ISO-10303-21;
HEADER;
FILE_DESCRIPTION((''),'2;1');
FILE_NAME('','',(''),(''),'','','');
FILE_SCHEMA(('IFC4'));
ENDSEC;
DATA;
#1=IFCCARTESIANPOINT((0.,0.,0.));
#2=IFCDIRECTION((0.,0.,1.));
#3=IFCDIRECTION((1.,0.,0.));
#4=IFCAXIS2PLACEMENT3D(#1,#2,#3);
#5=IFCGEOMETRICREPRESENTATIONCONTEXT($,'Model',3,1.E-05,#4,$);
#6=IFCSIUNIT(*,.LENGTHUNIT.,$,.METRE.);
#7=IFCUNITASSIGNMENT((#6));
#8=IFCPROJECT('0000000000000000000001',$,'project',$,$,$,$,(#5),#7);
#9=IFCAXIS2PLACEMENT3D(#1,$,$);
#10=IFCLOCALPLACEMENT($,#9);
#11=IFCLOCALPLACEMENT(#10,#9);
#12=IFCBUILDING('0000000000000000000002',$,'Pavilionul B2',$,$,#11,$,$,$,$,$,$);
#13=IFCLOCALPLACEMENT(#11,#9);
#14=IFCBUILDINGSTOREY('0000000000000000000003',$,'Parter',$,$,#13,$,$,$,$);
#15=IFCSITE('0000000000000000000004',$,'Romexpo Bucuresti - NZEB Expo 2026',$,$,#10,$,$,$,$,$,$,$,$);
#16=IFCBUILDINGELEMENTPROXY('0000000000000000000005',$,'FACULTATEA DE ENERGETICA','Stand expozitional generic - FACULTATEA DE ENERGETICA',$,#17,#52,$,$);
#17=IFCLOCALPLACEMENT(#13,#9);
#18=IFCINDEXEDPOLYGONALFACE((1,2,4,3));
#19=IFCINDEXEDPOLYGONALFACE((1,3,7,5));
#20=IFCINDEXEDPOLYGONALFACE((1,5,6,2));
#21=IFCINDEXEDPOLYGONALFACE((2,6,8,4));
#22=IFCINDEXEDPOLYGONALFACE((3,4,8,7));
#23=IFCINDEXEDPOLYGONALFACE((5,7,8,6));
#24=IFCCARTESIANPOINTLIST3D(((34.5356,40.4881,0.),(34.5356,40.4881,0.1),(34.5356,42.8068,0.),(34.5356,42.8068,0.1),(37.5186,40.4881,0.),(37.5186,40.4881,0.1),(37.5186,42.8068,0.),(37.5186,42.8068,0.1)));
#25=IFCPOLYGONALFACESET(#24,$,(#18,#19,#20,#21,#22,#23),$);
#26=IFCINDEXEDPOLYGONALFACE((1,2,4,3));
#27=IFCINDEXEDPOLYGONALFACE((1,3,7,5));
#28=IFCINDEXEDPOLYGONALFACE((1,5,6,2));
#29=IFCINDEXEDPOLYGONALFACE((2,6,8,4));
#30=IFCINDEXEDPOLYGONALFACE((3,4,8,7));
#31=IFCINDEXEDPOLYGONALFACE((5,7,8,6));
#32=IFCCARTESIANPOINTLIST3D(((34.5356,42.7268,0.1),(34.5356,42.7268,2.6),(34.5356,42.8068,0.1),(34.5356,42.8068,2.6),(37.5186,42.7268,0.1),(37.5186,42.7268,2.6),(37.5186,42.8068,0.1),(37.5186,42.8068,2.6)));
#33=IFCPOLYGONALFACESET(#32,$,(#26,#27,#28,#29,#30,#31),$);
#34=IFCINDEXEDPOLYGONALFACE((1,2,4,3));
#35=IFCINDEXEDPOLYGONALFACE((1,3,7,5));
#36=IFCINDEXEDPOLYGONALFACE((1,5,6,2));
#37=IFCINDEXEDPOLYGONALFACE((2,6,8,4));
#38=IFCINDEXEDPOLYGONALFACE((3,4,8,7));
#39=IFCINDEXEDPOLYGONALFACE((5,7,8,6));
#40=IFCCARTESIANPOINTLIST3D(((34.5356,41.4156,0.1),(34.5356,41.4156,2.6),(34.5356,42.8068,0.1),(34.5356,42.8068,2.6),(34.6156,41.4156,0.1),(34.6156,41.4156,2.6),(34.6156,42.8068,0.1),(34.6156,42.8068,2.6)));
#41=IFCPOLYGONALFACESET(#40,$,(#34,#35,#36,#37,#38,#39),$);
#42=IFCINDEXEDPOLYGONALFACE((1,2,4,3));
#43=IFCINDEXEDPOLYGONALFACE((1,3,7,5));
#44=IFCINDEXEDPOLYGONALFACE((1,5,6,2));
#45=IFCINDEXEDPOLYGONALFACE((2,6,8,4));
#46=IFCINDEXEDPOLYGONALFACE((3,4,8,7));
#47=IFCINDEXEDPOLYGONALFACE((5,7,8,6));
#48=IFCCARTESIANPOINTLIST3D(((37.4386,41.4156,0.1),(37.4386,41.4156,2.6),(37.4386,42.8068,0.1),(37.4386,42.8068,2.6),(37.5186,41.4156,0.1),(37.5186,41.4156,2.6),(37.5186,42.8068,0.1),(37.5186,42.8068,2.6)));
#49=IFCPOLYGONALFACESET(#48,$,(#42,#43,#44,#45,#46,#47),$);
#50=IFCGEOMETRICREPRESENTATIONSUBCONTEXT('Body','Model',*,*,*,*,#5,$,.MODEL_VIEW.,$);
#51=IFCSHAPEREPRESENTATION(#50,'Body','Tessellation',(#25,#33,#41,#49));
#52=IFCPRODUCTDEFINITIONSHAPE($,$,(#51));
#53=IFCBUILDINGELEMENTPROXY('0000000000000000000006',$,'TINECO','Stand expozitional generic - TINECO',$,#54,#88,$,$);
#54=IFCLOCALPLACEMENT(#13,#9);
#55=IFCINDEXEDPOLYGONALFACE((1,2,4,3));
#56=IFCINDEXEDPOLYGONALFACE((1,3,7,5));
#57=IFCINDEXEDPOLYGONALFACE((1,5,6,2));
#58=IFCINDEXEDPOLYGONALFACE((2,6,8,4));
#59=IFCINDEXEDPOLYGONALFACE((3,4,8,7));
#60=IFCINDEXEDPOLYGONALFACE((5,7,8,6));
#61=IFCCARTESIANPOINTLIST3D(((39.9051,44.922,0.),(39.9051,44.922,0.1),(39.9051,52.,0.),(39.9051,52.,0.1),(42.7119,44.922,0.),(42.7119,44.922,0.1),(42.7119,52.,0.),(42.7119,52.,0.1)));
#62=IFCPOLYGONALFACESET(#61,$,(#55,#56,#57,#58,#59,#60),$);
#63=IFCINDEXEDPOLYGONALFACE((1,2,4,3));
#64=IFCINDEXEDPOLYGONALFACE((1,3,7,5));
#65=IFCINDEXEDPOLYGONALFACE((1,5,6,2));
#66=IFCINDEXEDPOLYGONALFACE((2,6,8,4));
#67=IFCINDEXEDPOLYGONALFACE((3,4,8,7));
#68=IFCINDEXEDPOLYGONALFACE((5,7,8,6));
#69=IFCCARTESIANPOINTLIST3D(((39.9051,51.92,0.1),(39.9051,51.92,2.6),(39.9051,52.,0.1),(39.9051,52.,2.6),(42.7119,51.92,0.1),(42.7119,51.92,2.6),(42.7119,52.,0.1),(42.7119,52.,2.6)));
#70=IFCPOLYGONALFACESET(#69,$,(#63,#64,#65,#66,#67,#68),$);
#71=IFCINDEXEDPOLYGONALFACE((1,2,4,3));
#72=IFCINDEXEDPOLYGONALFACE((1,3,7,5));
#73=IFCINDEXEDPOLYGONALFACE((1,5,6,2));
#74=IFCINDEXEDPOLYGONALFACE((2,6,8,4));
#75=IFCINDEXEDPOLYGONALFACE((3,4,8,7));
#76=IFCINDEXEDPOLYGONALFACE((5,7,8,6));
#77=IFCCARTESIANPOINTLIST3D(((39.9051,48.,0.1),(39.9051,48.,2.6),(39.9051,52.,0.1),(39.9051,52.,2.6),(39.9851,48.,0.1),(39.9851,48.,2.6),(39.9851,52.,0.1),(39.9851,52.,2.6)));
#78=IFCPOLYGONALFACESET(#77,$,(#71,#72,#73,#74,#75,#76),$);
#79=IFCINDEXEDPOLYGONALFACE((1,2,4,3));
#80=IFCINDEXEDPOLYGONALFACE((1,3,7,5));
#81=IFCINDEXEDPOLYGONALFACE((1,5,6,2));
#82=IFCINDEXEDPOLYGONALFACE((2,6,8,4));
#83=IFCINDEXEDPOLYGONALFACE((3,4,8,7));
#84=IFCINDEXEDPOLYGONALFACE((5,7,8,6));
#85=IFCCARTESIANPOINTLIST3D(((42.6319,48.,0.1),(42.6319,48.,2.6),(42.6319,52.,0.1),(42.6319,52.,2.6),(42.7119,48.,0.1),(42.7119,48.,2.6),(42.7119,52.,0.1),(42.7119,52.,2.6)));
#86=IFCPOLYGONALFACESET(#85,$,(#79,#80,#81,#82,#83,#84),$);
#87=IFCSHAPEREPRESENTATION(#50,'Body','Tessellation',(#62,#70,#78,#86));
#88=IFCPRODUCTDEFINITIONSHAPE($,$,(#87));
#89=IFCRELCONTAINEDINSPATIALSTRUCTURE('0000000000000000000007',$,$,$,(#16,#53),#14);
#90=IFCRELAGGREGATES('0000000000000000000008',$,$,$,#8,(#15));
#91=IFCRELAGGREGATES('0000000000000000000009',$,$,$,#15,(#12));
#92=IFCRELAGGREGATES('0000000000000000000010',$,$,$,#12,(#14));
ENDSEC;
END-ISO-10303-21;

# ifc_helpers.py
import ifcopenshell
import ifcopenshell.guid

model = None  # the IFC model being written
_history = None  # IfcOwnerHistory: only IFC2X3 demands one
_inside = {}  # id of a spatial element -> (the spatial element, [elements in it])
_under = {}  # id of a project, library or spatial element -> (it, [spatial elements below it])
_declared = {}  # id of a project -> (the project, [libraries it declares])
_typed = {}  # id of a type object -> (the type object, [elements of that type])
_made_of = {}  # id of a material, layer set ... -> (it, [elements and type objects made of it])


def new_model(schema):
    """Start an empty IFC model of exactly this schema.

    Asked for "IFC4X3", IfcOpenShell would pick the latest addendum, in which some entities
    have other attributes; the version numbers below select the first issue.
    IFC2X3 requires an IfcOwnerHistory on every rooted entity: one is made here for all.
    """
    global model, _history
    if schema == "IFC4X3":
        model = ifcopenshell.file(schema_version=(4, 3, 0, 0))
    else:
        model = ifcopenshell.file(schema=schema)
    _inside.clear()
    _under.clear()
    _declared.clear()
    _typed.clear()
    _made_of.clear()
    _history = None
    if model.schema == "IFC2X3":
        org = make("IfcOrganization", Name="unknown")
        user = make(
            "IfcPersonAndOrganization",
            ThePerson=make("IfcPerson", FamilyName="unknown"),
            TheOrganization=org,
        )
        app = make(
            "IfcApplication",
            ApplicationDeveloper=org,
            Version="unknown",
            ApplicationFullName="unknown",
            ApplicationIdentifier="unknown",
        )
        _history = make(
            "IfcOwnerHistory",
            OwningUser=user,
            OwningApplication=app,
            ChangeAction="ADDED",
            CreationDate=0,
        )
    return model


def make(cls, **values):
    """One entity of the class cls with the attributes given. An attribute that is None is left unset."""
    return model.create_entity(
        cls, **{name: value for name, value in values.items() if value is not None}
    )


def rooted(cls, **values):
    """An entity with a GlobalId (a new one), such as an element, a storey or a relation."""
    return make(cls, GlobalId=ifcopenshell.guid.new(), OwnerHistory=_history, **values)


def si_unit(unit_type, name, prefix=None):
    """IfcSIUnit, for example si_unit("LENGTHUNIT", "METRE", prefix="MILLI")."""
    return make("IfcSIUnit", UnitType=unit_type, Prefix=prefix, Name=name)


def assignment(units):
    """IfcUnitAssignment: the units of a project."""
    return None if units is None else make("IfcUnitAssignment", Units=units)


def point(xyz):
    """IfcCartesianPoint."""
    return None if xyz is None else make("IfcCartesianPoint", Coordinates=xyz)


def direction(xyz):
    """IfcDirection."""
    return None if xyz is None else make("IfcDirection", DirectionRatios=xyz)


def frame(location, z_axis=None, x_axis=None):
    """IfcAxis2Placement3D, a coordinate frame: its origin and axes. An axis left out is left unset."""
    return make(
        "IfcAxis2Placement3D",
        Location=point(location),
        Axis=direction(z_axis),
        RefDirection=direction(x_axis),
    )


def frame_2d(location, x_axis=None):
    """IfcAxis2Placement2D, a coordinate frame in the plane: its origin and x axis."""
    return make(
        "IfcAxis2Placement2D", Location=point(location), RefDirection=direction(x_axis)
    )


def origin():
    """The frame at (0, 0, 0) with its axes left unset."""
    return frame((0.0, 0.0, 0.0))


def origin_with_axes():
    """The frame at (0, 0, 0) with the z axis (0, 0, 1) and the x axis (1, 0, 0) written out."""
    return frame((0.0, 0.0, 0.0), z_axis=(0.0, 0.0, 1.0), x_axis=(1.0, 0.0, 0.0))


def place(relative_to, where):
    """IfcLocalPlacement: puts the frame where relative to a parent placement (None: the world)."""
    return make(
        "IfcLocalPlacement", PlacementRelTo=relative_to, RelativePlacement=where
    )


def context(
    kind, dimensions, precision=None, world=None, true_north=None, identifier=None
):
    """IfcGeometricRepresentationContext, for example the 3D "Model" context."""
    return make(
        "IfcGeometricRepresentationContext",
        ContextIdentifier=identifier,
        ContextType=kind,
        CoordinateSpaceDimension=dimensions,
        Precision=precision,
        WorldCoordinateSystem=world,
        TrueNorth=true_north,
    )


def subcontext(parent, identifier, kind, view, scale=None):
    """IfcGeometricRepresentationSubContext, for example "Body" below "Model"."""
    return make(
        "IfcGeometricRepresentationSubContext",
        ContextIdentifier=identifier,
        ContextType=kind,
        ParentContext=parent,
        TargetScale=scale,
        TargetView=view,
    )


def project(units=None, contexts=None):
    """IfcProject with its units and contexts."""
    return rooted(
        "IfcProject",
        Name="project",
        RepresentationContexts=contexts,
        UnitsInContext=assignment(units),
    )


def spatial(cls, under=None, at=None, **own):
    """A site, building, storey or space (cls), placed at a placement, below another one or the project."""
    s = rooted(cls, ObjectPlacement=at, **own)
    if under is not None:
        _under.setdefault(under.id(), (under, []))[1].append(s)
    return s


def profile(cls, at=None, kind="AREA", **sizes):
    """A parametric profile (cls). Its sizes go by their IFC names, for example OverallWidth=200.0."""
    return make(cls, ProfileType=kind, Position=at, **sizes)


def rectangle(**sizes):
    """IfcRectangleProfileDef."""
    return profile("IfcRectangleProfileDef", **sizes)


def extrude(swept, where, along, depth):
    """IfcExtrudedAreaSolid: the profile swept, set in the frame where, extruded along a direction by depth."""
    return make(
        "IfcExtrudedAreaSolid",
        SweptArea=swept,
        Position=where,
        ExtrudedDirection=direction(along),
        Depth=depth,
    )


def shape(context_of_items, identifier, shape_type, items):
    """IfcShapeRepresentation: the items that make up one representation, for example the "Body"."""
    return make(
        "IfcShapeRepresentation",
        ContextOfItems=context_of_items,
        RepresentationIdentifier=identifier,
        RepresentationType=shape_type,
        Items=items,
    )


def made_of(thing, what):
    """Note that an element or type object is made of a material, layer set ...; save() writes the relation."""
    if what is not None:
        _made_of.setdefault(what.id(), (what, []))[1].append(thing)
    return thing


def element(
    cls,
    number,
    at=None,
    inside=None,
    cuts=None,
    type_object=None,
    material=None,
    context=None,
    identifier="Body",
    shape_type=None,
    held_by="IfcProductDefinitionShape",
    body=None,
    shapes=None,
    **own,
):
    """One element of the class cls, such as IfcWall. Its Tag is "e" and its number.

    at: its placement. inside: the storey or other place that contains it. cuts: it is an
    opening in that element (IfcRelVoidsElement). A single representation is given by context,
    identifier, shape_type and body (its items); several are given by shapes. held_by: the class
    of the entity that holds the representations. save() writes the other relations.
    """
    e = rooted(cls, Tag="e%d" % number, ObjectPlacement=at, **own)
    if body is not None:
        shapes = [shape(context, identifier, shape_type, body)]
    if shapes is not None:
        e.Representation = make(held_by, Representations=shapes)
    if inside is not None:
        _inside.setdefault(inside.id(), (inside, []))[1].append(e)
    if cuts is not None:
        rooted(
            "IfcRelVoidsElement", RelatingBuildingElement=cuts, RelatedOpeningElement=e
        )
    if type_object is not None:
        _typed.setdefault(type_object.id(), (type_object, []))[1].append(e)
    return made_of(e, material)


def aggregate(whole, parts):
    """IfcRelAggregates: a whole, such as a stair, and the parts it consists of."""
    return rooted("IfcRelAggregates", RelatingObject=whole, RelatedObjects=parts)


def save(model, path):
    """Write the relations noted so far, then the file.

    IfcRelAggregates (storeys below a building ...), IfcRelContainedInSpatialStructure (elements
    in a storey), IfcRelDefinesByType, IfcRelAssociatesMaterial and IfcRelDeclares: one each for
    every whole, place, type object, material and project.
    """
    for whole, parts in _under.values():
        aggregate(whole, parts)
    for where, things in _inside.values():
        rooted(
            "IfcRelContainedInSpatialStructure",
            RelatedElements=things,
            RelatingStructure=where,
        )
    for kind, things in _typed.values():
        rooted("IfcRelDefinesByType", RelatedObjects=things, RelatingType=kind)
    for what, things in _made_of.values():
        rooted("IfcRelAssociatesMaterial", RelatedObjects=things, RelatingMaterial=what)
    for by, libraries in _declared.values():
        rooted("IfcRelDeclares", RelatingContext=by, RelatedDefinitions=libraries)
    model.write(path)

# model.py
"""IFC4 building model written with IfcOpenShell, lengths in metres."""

from ifc_helpers import new_model, si_unit, frame, frame_2d, origin, origin_with_axes, place, context, subcontext, project, spatial, rectangle, extrude, element, save


model = new_model("IFC4")

# Units and contexts
model_context = context("Model", 3, precision=1e-05, world=origin_with_axes())
body_context = subcontext(model_context, "Body", "Model", "MODEL_VIEW")
ifc_project = project(units=[si_unit("LENGTHUNIT", "METRE")], contexts=[model_context])

# Site, building, storey
site_placement = place(None, origin())
site = spatial("IfcSite", under=ifc_project, at=site_placement, Name="Romexpo Bucuresti - NZEB Expo 2026")
building_placement = place(site_placement, origin())
building = spatial("IfcBuilding", under=site, at=building_placement, Name="Pavilionul B2")
storey_placement = place(building_placement, origin())
storey = spatial("IfcBuildingStorey", under=building, at=storey_placement, Name="Parter")

# Building element proxies
proxy_1_placement = place(storey_placement, frame((34.5356, 40.4881, 0.0), z_axis=(0.0, 0.0, 1.0), x_axis=(1.0, 0.0, 0.0)))
element("IfcBuildingElementProxy", 1, at=proxy_1_placement, inside=storey, Name="FACULTATEA DE ENERGETICA", Description="Stand expozitional generic - FACULTATEA DE ENERGETICA", context=body_context, shape_type="SweptSolid", body=[
    extrude(rectangle(XDim=2.9831, YDim=2.3186, at=frame_2d((1.4915, 1.1593))), origin(), (0.0, 0.0, 1.0), 0.1),
    extrude(rectangle(XDim=2.9831, YDim=0.08, at=frame_2d((1.4915, 2.2786))), frame((0.0, 0.0, 0.1)), (0.0, 0.0, 1.0), 2.5),
    extrude(rectangle(XDim=0.08, YDim=1.3912, at=frame_2d((0.04, 1.6231))), frame((0.0, 0.0, 0.1)), (0.0, 0.0, 1.0), 2.5),
    extrude(rectangle(XDim=0.08, YDim=1.3912, at=frame_2d((2.9431, 1.6231))), frame((0.0, 0.0, 0.1)), (0.0, 0.0, 1.0), 2.5),
])
proxy_2_placement = place(storey_placement, frame((39.9051, 44.922, 0.0), z_axis=(0.0, 0.0, 1.0), x_axis=(1.0, 0.0, 0.0)))
element("IfcBuildingElementProxy", 2, at=proxy_2_placement, inside=storey, Name="TINECO", Description="Stand expozitional generic - TINECO", context=body_context, shape_type="SweptSolid", body=[
    extrude(rectangle(XDim=2.8068, YDim=7.078, at=frame_2d((1.4034, 3.539))), origin(), (0.0, 0.0, 1.0), 0.1),
    extrude(rectangle(XDim=2.8068, YDim=0.08, at=frame_2d((1.4034, 7.038))), frame((0.0, 0.0, 0.1)), (0.0, 0.0, 1.0), 2.5),
    extrude(rectangle(XDim=0.08, YDim=4.0, at=frame_2d((0.04, 5.078))), frame((0.0, 0.0, 0.1)), (0.0, 0.0, 1.0), 2.5),
    extrude(rectangle(XDim=0.08, YDim=4.0, at=frame_2d((2.7668, 5.078))), frame((0.0, 0.0, 0.1)), (0.0, 0.0, 1.0), 2.5),
])

save(model, "model.ifc")
